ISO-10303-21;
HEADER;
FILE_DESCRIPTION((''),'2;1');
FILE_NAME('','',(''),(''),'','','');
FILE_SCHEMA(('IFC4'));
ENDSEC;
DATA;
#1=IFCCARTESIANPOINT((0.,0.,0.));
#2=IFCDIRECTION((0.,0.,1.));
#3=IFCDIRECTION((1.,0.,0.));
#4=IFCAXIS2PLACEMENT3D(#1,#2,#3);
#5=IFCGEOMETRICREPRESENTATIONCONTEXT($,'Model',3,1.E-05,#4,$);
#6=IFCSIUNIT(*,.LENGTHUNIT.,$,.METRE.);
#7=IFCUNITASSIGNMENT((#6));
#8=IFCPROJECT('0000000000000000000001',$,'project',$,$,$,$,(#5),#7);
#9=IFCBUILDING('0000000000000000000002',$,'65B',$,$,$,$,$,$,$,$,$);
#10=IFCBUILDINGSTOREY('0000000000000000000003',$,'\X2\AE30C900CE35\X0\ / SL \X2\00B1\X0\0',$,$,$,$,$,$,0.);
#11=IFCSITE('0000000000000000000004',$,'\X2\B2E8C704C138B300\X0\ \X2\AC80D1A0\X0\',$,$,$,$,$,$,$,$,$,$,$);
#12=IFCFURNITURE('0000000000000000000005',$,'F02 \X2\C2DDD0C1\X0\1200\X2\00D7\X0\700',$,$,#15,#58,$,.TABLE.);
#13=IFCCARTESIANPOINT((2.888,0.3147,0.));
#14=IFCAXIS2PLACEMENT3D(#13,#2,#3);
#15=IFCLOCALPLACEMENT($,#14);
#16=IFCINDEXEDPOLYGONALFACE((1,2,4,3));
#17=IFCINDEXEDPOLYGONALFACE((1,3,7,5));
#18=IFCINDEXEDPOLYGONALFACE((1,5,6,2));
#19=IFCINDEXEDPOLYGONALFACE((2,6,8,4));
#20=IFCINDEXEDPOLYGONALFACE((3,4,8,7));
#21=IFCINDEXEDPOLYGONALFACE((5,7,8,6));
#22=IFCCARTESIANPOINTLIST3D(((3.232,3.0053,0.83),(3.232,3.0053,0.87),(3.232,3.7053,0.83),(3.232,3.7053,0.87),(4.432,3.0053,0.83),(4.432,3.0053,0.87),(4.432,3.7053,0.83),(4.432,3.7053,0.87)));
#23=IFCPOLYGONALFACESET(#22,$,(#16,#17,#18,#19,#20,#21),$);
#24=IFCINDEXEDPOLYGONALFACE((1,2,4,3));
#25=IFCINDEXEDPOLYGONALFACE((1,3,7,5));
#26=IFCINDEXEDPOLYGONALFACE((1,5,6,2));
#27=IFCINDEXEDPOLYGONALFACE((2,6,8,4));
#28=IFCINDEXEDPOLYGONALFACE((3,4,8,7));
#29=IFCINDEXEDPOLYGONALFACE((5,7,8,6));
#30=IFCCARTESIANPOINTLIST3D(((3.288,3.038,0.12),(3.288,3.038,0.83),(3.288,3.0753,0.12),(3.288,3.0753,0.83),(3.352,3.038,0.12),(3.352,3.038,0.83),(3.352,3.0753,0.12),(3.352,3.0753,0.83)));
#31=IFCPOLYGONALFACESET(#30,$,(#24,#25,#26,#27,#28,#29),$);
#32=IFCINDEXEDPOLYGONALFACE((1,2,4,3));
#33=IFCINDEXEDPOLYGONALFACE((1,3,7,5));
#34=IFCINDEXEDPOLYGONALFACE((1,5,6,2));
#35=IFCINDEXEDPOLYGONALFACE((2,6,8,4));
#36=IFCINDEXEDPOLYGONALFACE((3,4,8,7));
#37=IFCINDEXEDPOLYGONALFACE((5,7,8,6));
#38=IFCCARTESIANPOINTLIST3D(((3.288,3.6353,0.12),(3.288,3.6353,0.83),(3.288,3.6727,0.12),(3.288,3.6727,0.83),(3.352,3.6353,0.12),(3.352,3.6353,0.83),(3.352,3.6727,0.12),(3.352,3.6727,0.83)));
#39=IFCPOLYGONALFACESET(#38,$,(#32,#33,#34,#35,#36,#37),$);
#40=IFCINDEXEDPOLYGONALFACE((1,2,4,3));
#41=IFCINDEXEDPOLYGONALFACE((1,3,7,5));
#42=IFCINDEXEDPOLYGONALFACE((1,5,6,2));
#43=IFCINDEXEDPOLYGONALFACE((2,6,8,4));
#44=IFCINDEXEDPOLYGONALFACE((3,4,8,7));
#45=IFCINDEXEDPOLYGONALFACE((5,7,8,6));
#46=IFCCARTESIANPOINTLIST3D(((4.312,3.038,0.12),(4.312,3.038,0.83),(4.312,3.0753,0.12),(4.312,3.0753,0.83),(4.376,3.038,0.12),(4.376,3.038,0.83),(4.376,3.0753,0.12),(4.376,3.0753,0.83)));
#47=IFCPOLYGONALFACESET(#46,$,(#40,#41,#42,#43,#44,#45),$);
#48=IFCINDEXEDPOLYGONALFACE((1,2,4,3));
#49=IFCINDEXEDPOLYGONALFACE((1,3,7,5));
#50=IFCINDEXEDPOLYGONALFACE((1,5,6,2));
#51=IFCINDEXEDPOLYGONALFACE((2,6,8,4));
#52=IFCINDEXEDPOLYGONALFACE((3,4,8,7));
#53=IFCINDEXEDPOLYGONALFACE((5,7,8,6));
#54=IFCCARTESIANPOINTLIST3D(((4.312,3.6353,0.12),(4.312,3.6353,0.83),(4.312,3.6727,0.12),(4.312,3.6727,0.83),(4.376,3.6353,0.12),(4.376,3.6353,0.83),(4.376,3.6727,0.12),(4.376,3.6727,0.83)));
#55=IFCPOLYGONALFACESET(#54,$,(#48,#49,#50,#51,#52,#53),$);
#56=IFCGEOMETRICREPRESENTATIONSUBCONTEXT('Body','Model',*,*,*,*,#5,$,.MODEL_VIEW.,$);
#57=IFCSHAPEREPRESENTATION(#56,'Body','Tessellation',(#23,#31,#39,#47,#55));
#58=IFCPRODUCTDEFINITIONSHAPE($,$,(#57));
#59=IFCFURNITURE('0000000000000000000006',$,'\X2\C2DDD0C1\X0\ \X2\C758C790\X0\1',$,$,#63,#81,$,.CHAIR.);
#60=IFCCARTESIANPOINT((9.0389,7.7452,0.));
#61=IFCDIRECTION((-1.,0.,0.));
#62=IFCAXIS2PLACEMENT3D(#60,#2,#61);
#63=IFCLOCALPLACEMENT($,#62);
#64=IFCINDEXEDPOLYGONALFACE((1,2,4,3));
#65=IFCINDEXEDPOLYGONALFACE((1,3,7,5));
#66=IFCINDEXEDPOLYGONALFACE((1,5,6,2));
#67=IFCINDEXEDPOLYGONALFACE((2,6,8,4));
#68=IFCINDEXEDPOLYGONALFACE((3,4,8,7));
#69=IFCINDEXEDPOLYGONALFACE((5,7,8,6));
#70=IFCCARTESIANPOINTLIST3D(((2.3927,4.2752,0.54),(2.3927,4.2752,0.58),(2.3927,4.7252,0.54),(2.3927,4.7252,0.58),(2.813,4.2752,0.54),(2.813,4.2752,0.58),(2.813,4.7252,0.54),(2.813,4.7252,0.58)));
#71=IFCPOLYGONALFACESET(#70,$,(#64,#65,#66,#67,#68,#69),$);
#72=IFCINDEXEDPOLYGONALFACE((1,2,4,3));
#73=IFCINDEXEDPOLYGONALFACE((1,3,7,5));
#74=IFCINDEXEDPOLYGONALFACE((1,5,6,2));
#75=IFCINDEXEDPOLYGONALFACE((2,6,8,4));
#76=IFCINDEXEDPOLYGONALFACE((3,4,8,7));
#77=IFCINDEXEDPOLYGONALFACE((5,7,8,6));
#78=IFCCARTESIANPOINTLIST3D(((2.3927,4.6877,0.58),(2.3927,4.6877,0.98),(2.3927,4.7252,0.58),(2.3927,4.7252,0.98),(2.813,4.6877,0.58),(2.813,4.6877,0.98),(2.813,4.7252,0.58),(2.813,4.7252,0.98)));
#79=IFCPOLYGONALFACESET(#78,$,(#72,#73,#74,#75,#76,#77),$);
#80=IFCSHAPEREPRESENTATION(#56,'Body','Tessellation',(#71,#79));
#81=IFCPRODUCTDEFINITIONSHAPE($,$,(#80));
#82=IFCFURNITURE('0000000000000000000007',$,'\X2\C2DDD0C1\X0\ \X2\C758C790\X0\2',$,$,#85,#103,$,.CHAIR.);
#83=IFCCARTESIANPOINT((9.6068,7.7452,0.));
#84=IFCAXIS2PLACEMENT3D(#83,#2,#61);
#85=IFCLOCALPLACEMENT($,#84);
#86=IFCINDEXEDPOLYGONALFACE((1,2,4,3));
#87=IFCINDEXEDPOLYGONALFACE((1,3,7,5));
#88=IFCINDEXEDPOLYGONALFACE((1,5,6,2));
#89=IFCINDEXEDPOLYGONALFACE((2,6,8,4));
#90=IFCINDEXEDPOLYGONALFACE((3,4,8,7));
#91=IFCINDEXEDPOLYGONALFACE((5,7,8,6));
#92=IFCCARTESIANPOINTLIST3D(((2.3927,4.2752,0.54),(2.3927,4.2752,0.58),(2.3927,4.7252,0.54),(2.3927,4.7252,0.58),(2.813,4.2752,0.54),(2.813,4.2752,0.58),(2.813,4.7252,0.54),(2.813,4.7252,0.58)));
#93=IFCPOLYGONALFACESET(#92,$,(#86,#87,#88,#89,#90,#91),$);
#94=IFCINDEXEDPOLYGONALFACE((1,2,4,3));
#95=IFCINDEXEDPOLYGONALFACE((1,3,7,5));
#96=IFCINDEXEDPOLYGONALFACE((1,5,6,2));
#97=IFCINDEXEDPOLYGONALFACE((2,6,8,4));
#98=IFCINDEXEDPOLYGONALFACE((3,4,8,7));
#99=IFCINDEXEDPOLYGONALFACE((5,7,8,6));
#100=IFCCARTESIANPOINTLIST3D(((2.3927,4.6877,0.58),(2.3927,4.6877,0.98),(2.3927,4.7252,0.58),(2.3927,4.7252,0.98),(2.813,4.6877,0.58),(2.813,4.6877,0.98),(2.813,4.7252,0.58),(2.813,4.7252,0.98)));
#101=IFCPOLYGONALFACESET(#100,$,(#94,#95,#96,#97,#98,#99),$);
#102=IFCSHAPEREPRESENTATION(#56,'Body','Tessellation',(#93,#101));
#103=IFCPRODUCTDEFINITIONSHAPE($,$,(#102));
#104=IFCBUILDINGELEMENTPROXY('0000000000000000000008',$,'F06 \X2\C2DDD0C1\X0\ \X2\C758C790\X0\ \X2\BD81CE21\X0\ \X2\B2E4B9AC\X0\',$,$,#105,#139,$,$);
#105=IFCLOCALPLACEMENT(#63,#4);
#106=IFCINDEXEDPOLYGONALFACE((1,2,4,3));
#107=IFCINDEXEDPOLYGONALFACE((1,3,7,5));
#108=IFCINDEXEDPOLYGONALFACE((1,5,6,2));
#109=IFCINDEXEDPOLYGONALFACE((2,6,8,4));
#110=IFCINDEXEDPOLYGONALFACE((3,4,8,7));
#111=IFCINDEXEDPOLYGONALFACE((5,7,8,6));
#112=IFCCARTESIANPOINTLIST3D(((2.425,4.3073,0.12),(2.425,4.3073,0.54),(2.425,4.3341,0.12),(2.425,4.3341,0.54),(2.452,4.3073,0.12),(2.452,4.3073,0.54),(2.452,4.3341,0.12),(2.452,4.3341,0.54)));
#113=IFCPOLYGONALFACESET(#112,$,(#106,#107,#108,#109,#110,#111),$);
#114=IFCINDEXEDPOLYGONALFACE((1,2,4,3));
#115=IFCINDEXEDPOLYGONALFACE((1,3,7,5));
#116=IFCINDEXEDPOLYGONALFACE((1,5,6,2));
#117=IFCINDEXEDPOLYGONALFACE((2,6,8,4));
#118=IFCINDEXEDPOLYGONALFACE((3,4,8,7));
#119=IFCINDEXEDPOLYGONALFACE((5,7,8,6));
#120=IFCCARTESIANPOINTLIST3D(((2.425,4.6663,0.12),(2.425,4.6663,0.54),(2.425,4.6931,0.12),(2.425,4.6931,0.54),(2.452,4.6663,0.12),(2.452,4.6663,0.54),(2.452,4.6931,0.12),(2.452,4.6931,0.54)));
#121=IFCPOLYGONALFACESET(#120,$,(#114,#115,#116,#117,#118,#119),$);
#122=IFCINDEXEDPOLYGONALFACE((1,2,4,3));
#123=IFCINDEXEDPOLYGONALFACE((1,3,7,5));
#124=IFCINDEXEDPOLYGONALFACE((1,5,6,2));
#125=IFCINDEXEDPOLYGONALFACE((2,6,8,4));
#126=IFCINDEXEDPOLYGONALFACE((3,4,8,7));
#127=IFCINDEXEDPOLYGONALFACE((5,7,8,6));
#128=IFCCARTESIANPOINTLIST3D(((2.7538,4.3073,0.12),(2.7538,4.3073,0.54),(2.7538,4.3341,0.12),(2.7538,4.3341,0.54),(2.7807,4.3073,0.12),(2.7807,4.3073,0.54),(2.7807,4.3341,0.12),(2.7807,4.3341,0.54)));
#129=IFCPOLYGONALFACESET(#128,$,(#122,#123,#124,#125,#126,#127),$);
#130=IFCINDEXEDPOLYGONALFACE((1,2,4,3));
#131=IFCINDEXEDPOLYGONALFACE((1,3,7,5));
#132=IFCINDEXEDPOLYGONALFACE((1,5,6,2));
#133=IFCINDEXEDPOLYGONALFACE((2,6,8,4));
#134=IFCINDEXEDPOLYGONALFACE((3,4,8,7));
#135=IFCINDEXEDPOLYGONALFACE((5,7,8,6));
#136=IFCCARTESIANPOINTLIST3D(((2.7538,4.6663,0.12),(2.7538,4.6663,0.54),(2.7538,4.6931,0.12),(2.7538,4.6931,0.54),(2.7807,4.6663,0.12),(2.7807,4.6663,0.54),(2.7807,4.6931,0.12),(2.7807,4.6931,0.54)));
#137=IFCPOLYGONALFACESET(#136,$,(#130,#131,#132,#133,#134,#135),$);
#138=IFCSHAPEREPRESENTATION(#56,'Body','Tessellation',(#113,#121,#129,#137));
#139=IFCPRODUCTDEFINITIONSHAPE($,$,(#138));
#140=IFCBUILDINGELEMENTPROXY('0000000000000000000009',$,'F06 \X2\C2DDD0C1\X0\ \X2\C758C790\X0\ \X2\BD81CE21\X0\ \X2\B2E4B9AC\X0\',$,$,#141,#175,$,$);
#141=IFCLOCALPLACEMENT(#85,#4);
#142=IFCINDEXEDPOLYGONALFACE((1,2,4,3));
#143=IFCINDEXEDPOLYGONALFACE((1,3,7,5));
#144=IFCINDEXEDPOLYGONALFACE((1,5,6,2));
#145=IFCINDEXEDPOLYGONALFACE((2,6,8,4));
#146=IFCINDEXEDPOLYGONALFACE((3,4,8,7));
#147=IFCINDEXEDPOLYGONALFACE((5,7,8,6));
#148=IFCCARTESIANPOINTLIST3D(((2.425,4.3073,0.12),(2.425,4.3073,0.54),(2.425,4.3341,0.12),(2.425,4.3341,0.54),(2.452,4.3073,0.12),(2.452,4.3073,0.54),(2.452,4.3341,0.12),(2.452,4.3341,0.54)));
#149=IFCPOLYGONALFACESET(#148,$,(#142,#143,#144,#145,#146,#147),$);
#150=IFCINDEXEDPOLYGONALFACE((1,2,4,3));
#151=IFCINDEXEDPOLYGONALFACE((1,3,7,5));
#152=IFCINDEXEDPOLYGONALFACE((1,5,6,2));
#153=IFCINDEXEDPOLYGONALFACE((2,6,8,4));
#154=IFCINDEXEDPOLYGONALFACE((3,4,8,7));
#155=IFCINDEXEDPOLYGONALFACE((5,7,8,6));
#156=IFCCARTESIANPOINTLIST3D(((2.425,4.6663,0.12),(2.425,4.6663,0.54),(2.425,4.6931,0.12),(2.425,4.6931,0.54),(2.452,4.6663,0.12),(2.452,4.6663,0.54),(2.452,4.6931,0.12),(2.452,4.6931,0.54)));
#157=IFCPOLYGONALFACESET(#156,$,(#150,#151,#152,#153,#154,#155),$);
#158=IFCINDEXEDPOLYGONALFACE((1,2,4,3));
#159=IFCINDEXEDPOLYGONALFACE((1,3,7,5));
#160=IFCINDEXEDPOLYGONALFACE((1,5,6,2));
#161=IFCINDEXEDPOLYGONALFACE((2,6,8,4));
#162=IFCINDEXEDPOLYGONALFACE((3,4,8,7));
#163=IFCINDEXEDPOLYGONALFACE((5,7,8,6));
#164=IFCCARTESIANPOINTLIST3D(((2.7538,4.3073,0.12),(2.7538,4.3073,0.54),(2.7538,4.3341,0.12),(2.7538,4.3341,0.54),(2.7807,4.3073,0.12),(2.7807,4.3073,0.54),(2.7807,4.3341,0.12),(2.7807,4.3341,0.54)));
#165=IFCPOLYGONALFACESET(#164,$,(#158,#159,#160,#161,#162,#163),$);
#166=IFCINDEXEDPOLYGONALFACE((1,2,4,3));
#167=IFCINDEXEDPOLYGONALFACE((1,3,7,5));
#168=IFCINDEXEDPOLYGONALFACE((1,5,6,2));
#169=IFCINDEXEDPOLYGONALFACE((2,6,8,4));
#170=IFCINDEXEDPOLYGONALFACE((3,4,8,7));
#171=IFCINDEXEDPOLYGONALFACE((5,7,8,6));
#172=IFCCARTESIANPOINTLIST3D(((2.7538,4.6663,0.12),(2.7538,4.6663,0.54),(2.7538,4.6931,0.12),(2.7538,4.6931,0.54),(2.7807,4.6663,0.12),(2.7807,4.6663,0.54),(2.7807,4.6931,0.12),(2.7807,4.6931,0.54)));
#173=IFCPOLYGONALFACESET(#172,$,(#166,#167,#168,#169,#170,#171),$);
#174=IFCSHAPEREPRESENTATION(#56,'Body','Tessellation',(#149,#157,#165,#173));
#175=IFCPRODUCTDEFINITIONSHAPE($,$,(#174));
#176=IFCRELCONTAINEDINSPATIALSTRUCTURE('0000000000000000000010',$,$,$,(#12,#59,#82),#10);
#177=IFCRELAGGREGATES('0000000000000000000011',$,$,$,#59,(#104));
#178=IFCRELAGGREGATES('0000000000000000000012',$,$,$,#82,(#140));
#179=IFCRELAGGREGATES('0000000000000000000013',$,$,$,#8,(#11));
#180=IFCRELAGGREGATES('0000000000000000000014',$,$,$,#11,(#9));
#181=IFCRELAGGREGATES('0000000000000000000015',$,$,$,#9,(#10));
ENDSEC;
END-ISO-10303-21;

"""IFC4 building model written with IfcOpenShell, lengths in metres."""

from ifc_helpers import new_model, si_unit, frame, origin_with_axes, place, context, subcontext, project, spatial, polyline, outline, extrude, element, aggregate, save


model = new_model("IFC4")

# Units and contexts
model_context = context("Model", 3, precision=1e-05, world=origin_with_axes())
body_context = subcontext(model_context, "Body", "Model", "MODEL_VIEW")
ifc_project = project(units=[si_unit("LENGTHUNIT", "METRE")], contexts=[model_context])

# Site, building, storey
site = spatial("IfcSite", under=ifc_project, Name="단위세대 검토")
building = spatial("IfcBuilding", under=site, Name="65B")
storey = spatial("IfcBuildingStorey", under=building, Name="기준층 / SL ±0", Elevation=0.0)

# Furniture
furniture_1_placement = place(None, frame((2.888, 0.3147, 0.0), z_axis=(0.0, 0.0, 1.0), x_axis=(1.0, 0.0, 0.0)))
element("IfcFurniture", 1, at=furniture_1_placement, inside=storey, Name="F02 식탁1200×700", PredefinedType="TABLE", context=body_context, shape_type="SweptSolid", body=[
    extrude(outline(polyline([(4.432, 3.7053), (4.432, 3.0053), (3.232, 3.0053), (3.232, 3.7053), (4.432, 3.7053)])), frame((0.0, 0.0, 0.83)), (0.0, 0.0, 1.0), 0.04),
    extrude(outline(polyline([(3.352, 3.038), (3.352, 3.0753), (3.288, 3.0753), (3.288, 3.038), (3.352, 3.038)])), frame((0.0, 0.0, 0.12)), (0.0, 0.0, 1.0), 0.71),
    extrude(outline(polyline([(3.352, 3.6353), (3.352, 3.6727), (3.288, 3.6727), (3.288, 3.6353), (3.352, 3.6353)])), frame((0.0, 0.0, 0.12)), (0.0, 0.0, 1.0), 0.71),
    extrude(outline(polyline([(4.376, 3.038), (4.376, 3.0753), (4.312, 3.0753), (4.312, 3.038), (4.376, 3.038)])), frame((0.0, 0.0, 0.12)), (0.0, 0.0, 1.0), 0.71),
    extrude(outline(polyline([(4.376, 3.6353), (4.376, 3.6727), (4.312, 3.6727), (4.312, 3.6353), (4.376, 3.6353)])), frame((0.0, 0.0, 0.12)), (0.0, 0.0, 1.0), 0.71),
])
furniture_2_placement = place(None, frame((9.0389, 7.7452, 0.0), z_axis=(0.0, 0.0, 1.0), x_axis=(-1.0, 0.0, 0.0)))
furniture_2 = element("IfcFurniture", 2, at=furniture_2_placement, inside=storey, Name="식탁 의자1", PredefinedType="CHAIR", context=body_context, shape_type="SweptSolid", body=[
    extrude(outline(polyline([(2.813, 4.2752), (2.813, 4.7252), (2.3927, 4.7252), (2.3927, 4.2752), (2.813, 4.2752)])), frame((0.0, 0.0, 0.54)), (0.0, 0.0, 1.0), 0.04),
    extrude(outline(polyline([(2.813, 4.6877), (2.813, 4.7252), (2.3927, 4.7252), (2.3927, 4.6877), (2.813, 4.6877)])), frame((0.0, 0.0, 0.58)), (0.0, 0.0, 1.0), 0.4),
])
furniture_3_placement = place(None, frame((9.6068, 7.7452, 0.0), z_axis=(0.0, 0.0, 1.0), x_axis=(-1.0, 0.0, 0.0)))
furniture_3 = element("IfcFurniture", 3, at=furniture_3_placement, inside=storey, Name="식탁 의자2", PredefinedType="CHAIR", context=body_context, shape_type="SweptSolid", body=[
    extrude(outline(polyline([(2.813, 4.2752), (2.813, 4.7252), (2.3927, 4.7252), (2.3927, 4.2752), (2.813, 4.2752)])), frame((0.0, 0.0, 0.54)), (0.0, 0.0, 1.0), 0.04),
    extrude(outline(polyline([(2.813, 4.6877), (2.813, 4.7252), (2.3927, 4.7252), (2.3927, 4.6877), (2.813, 4.6877)])), frame((0.0, 0.0, 0.58)), (0.0, 0.0, 1.0), 0.4),
])

# Building element proxies
proxy_1_placement = place(furniture_2_placement, origin_with_axes())
proxy_1 = element("IfcBuildingElementProxy", 4, at=proxy_1_placement, Name="F06 식탁 의자 북측 다리", context=body_context, shape_type="SweptSolid", body=[
    extrude(outline(polyline([(2.452, 4.3073), (2.452, 4.3341), (2.425, 4.3341), (2.425, 4.3073), (2.452, 4.3073)])), frame((0.0, 0.0, 0.12)), (0.0, 0.0, 1.0), 0.42),
    extrude(outline(polyline([(2.452, 4.6663), (2.452, 4.6931), (2.425, 4.6931), (2.425, 4.6663), (2.452, 4.6663)])), frame((0.0, 0.0, 0.12)), (0.0, 0.0, 1.0), 0.42),
    extrude(outline(polyline([(2.7807, 4.3073), (2.7807, 4.3341), (2.7538, 4.3341), (2.7538, 4.3073), (2.7807, 4.3073)])), frame((0.0, 0.0, 0.12)), (0.0, 0.0, 1.0), 0.42),
    extrude(outline(polyline([(2.7807, 4.6663), (2.7807, 4.6931), (2.7538, 4.6931), (2.7538, 4.6663), (2.7807, 4.6663)])), frame((0.0, 0.0, 0.12)), (0.0, 0.0, 1.0), 0.42),
])
aggregate(furniture_2, [proxy_1])
proxy_2_placement = place(furniture_3_placement, origin_with_axes())
proxy_2 = element("IfcBuildingElementProxy", 5, at=proxy_2_placement, Name="F06 식탁 의자 북측 다리", context=body_context, shape_type="SweptSolid", body=[
    extrude(outline(polyline([(2.452, 4.3073), (2.452, 4.3341), (2.425, 4.3341), (2.425, 4.3073), (2.452, 4.3073)])), frame((0.0, 0.0, 0.12)), (0.0, 0.0, 1.0), 0.42),
    extrude(outline(polyline([(2.452, 4.6663), (2.452, 4.6931), (2.425, 4.6931), (2.425, 4.6663), (2.452, 4.6663)])), frame((0.0, 0.0, 0.12)), (0.0, 0.0, 1.0), 0.42),
    extrude(outline(polyline([(2.7807, 4.3073), (2.7807, 4.3341), (2.7538, 4.3341), (2.7538, 4.3073), (2.7807, 4.3073)])), frame((0.0, 0.0, 0.12)), (0.0, 0.0, 1.0), 0.42),
    extrude(outline(polyline([(2.7807, 4.6663), (2.7807, 4.6931), (2.7538, 4.6931), (2.7538, 4.6663), (2.7807, 4.6663)])), frame((0.0, 0.0, 0.12)), (0.0, 0.0, 1.0), 0.42),
])
aggregate(furniture_3, [proxy_2])

save(model, "model.ifc")
